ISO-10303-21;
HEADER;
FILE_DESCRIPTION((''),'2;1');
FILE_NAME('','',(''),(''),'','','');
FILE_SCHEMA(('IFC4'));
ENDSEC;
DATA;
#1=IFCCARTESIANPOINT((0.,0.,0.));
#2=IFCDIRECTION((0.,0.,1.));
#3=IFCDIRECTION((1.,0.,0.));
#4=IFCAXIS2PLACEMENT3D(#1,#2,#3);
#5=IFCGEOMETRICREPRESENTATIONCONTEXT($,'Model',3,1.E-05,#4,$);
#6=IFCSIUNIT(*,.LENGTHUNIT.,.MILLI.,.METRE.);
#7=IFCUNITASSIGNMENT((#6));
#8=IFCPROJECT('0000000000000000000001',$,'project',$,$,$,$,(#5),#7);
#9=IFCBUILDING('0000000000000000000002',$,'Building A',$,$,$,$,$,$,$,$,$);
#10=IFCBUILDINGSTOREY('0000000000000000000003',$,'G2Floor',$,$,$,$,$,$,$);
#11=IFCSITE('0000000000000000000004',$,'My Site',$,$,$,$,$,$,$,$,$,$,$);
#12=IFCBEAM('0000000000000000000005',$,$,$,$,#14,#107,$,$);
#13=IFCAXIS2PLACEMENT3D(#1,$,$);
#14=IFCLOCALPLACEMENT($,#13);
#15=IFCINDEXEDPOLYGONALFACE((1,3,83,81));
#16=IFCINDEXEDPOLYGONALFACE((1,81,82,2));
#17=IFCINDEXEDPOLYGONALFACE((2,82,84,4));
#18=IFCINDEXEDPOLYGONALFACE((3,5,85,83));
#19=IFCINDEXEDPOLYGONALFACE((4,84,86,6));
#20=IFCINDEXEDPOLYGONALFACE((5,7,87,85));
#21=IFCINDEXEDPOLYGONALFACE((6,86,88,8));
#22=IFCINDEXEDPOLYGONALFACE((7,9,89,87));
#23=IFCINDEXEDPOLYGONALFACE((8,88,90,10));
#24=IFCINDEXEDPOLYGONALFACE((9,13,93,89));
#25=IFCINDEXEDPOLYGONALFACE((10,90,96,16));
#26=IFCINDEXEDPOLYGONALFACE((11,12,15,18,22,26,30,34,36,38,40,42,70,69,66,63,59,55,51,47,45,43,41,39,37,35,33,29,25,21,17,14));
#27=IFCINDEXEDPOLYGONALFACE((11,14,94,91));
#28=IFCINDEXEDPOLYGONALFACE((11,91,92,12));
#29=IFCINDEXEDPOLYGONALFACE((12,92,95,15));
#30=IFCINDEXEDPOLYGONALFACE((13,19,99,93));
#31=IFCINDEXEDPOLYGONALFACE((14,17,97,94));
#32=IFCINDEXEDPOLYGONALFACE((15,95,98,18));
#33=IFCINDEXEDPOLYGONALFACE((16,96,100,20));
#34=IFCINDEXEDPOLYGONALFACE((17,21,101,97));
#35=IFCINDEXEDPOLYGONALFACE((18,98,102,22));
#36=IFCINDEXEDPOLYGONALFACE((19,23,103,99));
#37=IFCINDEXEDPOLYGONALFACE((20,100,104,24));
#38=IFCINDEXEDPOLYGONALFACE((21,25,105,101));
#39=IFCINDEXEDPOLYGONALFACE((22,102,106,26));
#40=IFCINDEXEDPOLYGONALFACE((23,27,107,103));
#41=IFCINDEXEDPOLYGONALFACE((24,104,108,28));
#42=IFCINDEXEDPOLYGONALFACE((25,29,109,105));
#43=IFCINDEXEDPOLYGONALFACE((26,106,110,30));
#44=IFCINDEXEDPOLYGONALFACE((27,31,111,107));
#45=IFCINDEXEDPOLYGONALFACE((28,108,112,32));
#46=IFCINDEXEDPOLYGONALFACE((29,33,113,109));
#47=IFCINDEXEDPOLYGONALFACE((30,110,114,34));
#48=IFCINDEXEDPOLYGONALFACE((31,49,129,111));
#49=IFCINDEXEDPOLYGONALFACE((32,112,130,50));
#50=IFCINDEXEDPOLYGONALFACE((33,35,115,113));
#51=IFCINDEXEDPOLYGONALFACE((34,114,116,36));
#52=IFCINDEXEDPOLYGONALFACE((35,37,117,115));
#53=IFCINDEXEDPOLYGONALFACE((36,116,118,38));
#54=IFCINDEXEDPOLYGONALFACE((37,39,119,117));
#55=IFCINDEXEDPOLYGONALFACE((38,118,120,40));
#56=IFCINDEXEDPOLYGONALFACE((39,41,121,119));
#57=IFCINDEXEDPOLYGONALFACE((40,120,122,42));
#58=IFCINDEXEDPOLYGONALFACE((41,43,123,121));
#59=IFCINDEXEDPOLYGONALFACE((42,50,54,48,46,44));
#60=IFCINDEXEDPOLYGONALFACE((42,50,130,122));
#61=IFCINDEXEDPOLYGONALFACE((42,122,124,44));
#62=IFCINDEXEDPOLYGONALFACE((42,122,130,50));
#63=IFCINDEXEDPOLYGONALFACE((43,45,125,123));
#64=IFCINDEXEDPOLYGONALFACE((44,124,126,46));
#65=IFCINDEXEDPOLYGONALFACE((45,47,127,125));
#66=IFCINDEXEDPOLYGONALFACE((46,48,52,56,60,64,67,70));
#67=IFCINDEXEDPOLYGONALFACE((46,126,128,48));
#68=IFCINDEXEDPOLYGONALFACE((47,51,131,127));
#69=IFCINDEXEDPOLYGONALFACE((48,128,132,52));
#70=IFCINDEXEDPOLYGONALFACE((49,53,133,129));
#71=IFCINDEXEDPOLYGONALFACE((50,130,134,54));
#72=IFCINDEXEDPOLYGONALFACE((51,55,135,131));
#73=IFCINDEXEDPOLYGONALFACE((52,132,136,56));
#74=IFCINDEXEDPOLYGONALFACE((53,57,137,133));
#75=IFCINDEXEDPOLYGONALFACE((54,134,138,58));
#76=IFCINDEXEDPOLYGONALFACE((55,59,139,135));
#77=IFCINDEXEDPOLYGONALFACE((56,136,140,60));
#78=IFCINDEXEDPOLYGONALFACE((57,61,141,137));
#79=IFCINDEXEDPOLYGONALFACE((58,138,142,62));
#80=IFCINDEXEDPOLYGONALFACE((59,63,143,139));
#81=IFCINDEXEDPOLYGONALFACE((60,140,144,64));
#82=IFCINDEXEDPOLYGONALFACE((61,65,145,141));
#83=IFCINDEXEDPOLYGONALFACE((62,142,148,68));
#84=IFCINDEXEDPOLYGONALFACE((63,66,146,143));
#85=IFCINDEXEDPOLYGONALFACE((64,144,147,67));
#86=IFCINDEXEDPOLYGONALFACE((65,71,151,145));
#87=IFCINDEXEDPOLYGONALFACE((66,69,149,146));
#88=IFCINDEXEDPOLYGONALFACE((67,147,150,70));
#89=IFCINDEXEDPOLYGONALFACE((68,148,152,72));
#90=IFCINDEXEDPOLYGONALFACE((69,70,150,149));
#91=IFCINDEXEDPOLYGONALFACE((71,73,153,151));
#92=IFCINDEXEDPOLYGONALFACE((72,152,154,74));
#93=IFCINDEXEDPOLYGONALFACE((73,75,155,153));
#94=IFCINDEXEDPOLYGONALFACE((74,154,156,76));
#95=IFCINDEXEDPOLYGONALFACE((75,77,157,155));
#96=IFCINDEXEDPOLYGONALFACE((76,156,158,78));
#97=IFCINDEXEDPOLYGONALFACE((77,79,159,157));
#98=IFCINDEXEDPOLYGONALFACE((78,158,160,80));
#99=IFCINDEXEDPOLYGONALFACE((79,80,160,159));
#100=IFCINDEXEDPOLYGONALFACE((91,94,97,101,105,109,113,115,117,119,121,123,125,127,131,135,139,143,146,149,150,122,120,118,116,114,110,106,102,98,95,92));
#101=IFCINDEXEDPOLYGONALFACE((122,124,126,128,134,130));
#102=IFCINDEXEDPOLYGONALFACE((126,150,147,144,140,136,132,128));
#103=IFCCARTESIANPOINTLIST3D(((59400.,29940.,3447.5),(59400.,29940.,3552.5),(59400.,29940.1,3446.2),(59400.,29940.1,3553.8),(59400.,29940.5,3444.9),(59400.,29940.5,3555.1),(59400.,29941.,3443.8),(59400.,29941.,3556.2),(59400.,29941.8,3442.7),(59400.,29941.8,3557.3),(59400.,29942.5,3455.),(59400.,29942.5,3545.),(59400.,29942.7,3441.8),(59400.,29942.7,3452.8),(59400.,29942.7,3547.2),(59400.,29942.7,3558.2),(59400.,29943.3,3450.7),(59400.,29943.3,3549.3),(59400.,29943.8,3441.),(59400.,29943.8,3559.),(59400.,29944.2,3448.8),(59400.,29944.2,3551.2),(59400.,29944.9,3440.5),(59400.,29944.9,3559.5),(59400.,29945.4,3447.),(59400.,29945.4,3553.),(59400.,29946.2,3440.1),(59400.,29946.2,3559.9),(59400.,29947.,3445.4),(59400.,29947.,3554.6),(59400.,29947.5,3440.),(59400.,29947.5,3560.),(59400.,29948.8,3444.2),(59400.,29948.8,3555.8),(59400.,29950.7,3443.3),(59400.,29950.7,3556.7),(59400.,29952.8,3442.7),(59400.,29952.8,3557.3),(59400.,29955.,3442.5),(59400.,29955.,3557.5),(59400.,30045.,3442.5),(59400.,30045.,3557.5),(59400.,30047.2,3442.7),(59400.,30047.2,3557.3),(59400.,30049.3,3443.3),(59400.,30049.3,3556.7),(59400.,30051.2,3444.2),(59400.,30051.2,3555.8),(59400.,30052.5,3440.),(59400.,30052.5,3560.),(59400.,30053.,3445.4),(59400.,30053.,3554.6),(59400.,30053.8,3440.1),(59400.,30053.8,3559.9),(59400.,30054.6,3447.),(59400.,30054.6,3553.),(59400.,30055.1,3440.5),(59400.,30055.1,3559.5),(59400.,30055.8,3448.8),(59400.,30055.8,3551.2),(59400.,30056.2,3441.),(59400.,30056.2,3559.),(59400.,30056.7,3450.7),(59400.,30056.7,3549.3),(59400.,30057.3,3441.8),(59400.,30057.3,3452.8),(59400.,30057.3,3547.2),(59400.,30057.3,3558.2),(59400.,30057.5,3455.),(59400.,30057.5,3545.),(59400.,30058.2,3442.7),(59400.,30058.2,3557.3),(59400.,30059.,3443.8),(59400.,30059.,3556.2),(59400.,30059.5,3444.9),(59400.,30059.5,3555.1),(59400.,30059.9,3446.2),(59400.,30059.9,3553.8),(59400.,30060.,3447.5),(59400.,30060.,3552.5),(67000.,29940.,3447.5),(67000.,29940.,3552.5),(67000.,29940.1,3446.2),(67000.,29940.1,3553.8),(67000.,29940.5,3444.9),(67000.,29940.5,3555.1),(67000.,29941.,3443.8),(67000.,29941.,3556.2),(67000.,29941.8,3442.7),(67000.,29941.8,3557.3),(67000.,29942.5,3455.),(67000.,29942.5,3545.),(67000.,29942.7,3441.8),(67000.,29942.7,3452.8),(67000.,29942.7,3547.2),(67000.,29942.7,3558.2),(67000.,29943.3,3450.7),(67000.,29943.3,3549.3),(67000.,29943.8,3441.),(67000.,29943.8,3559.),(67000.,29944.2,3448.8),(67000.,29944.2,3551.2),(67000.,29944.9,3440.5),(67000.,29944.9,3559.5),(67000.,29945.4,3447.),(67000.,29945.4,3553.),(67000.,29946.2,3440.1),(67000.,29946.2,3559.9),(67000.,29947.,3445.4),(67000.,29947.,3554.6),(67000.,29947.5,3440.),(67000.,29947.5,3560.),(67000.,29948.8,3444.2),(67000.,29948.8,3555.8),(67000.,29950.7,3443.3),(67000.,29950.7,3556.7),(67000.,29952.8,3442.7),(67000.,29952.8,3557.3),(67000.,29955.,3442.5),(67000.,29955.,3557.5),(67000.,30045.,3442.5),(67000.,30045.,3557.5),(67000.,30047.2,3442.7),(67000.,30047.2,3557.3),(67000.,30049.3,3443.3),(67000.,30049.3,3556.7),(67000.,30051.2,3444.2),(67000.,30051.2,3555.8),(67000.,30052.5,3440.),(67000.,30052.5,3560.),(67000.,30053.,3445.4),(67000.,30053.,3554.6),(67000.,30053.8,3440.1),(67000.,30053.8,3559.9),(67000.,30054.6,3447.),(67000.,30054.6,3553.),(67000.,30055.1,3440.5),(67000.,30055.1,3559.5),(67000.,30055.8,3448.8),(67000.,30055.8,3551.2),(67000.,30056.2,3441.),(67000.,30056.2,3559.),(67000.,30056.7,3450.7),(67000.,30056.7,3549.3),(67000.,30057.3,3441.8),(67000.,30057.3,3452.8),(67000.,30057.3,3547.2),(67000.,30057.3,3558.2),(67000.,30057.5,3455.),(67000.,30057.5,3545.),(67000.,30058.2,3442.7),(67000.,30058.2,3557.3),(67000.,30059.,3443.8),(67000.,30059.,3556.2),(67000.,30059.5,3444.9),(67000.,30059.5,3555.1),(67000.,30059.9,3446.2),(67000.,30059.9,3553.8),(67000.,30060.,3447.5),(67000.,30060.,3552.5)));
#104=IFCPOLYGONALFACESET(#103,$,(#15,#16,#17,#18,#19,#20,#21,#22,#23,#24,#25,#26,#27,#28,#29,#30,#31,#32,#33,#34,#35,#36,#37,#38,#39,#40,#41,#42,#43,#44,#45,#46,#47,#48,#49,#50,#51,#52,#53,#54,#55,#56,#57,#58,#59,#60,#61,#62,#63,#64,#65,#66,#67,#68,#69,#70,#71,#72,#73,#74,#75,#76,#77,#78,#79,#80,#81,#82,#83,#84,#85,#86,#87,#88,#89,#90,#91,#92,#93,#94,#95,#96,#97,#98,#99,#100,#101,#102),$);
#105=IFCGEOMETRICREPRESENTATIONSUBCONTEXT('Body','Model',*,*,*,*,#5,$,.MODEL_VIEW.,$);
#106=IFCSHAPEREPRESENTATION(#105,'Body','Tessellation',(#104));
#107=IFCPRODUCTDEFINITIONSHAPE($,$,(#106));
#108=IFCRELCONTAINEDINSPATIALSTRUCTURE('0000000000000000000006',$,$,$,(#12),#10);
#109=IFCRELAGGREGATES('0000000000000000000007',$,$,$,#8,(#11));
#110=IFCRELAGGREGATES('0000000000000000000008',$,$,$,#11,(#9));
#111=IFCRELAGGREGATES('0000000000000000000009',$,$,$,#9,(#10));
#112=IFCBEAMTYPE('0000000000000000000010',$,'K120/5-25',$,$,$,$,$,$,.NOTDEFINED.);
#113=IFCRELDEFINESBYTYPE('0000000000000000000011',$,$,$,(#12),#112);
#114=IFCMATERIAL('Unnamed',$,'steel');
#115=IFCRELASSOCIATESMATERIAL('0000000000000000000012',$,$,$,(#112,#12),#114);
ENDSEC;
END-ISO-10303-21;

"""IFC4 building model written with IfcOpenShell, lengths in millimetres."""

from ifc_helpers import new_model, si_unit, frame, origin_with_axes, place, context, subcontext, project, spatial, polyline, outline, extrude, material, material_profile, profile_set, profile_usage, type_object, element, save


model = new_model("IFC4")

# Units and contexts
model_context = context("Model", 3, precision=1e-05, world=origin_with_axes())
body_context = subcontext(model_context, "Body", "Model", "MODEL_VIEW")
ifc_project = project(units=[si_unit("LENGTHUNIT", "METRE", prefix="MILLI")], contexts=[model_context])

# Site, building, storey
site = spatial("IfcSite", under=ifc_project, Name="My Site")
building = spatial("IfcBuilding", under=site, Name="Building A")
storey = spatial("IfcBuildingStorey", under=building, Name="G2Floor")

# Beam
ifc_material_1 = material(Name="Unnamed", Category="steel")
ifc_material_profile_1 = material_profile(ifc_material_1, outline(polyline([(-52.5, -60.0), (52.5, -60.0), (52.5, -60.0), (53.8, -59.9), (53.8, -59.9), (55.1, -59.5), (55.1, -59.5), (56.2, -59.0), (56.2, -59.0), (57.3, -58.2), (57.3, -58.2), (58.2, -57.3), (58.2, -57.3), (59.0, -56.2), (59.0, -56.2), (59.5, -55.1), (59.5, -55.1), (59.9, -53.8), (59.9, -53.8), (60.0, -52.5), (60.0, -52.5), (60.0, 52.5), (60.0, 52.5), (59.9, 53.8), (59.9, 53.8), (59.5, 55.1), (59.5, 55.1), (59.0, 56.2), (59.0, 56.2), (58.2, 57.3), (58.2, 57.3), (57.3, 58.2), (57.3, 58.2), (56.2, 59.0), (56.2, 59.0), (55.1, 59.5), (55.1, 59.5), (53.8, 59.9), (53.8, 59.9), (52.5, 60.0), (52.5, 60.0), (-52.5, 60.0), (-52.5, 60.0), (-53.8, 59.9), (-53.8, 59.9), (-55.1, 59.5), (-55.1, 59.5), (-56.2, 59.0), (-56.2, 59.0), (-57.3, 58.2), (-57.3, 58.2), (-58.2, 57.3), (-58.2, 57.3), (-59.0, 56.2), (-59.0, 56.2), (-59.5, 55.1), (-59.5, 55.1), (-59.9, 53.8), (-59.9, 53.8), (-60.0, 52.5), (-60.0, 52.5), (-60.0, -52.5), (-60.0, -52.5), (-59.9, -53.8), (-59.9, -53.8), (-59.5, -55.1), (-59.5, -55.1), (-59.0, -56.2), (-59.0, -56.2), (-58.2, -57.3), (-58.2, -57.3), (-57.3, -58.2), (-57.3, -58.2), (-56.2, -59.0), (-56.2, -59.0), (-55.1, -59.5), (-55.1, -59.5), (-53.8, -59.9), (-53.8, -59.9), (-52.5, -60.0), (-52.5, -60.0), (-45.0, -57.5), (-45.0, -57.5), (45.0, -57.5), (45.0, -57.5), (47.2, -57.3), (47.2, -57.3), (49.3, -56.7), (49.3, -56.7), (51.2, -55.8), (51.2, -55.8), (53.0, -54.6), (53.0, -54.6), (54.6, -53.0), (54.6, -53.0), (55.8, -51.2), (55.8, -51.2), (56.7, -49.3), (56.7, -49.3), (57.3, -47.2), (57.3, -47.2), (57.5, -45.0), (57.5, -45.0), (57.5, 45.0), (57.5, 45.0), (57.3, 47.2), (57.3, 47.2), (56.7, 49.3), (56.7, 49.3), (55.8, 51.2), (55.8, 51.2), (54.6, 53.0), (54.6, 53.0), (53.0, 54.6), (53.0, 54.6), (51.2, 55.8), (51.2, 55.8), (49.3, 56.7), (49.3, 56.7), (47.2, 57.3), (47.2, 57.3), (45.0, 57.5), (45.0, 57.5), (-45.0, 57.5), (-45.0, 57.5), (-47.2, 57.3), (-47.2, 57.3), (-49.3, 56.7), (-49.3, 56.7), (-51.2, 55.8), (-51.2, 55.8), (-53.0, 54.6), (-53.0, 54.6), (-54.6, 53.0), (-54.6, 53.0), (-55.8, 51.2), (-55.8, 51.2), (-56.7, 49.3), (-56.7, 49.3), (-57.3, 47.2), (-57.3, 47.2), (-57.5, 45.0), (-57.5, 45.0), (-57.5, -45.0), (-57.5, -45.0), (-57.3, -47.2), (-57.3, -47.2), (-56.7, -49.3), (-56.7, -49.3), (-55.8, -51.2), (-55.8, -51.2), (-54.6, -53.0), (-54.6, -53.0), (-53.0, -54.6), (-53.0, -54.6), (-51.2, -55.8), (-51.2, -55.8), (-49.3, -56.7), (-49.3, -56.7), (-47.2, -57.3), (-47.2, -57.3), (-45.0, -57.5), (-45.0, -57.5), (-52.5, -60.0)])))
ifc_profile_set_1 = profile_set([ifc_material_profile_1], Name="K120/5-25")
ifc_profile_usage_1 = profile_usage(ifc_profile_set_1)
beam_type_1 = type_object("IfcBeamType", Name="K120/5-25", PredefinedType="NOTDEFINED", material=ifc_profile_set_1)
beam_1_placement = place(None, frame((59400.0, 30000.0, 3500.0), z_axis=(1.0, 0.0, 0.0), x_axis=(0.0, -1.0, 0.0)))
element("IfcBeam", 1, at=beam_1_placement, inside=storey, type_object=beam_type_1, material=ifc_profile_usage_1, context=body_context, shape_type="SweptSolid", body=[
    extrude(outline(polyline([(-52.5, -60.0), (52.5, -60.0), (52.5, -60.0), (53.8, -59.9), (53.8, -59.9), (55.1, -59.5), (55.1, -59.5), (56.2, -59.0), (56.2, -59.0), (57.3, -58.2), (57.3, -58.2), (58.2, -57.3), (58.2, -57.3), (59.0, -56.2), (59.0, -56.2), (59.5, -55.1), (59.5, -55.1), (59.9, -53.8), (59.9, -53.8), (60.0, -52.5), (60.0, -52.5), (60.0, 52.5), (60.0, 52.5), (59.9, 53.8), (59.9, 53.8), (59.5, 55.1), (59.5, 55.1), (59.0, 56.2), (59.0, 56.2), (58.2, 57.3), (58.2, 57.3), (57.3, 58.2), (57.3, 58.2), (56.2, 59.0), (56.2, 59.0), (55.1, 59.5), (55.1, 59.5), (53.8, 59.9), (53.8, 59.9), (52.5, 60.0), (52.5, 60.0), (-52.5, 60.0), (-52.5, 60.0), (-53.8, 59.9), (-53.8, 59.9), (-55.1, 59.5), (-55.1, 59.5), (-56.2, 59.0), (-56.2, 59.0), (-57.3, 58.2), (-57.3, 58.2), (-58.2, 57.3), (-58.2, 57.3), (-59.0, 56.2), (-59.0, 56.2), (-59.5, 55.1), (-59.5, 55.1), (-59.9, 53.8), (-59.9, 53.8), (-60.0, 52.5), (-60.0, 52.5), (-60.0, -52.5), (-60.0, -52.5), (-59.9, -53.8), (-59.9, -53.8), (-59.5, -55.1), (-59.5, -55.1), (-59.0, -56.2), (-59.0, -56.2), (-58.2, -57.3), (-58.2, -57.3), (-57.3, -58.2), (-57.3, -58.2), (-56.2, -59.0), (-56.2, -59.0), (-55.1, -59.5), (-55.1, -59.5), (-53.8, -59.9), (-53.8, -59.9), (-52.5, -60.0), (-52.5, -60.0), (-45.0, -57.5), (-45.0, -57.5), (45.0, -57.5), (45.0, -57.5), (47.2, -57.3), (47.2, -57.3), (49.3, -56.7), (49.3, -56.7), (51.2, -55.8), (51.2, -55.8), (53.0, -54.6), (53.0, -54.6), (54.6, -53.0), (54.6, -53.0), (55.8, -51.2), (55.8, -51.2), (56.7, -49.3), (56.7, -49.3), (57.3, -47.2), (57.3, -47.2), (57.5, -45.0), (57.5, -45.0), (57.5, 45.0), (57.5, 45.0), (57.3, 47.2), (57.3, 47.2), (56.7, 49.3), (56.7, 49.3), (55.8, 51.2), (55.8, 51.2), (54.6, 53.0), (54.6, 53.0), (53.0, 54.6), (53.0, 54.6), (51.2, 55.8), (51.2, 55.8), (49.3, 56.7), (49.3, 56.7), (47.2, 57.3), (47.2, 57.3), (45.0, 57.5), (45.0, 57.5), (-45.0, 57.5), (-45.0, 57.5), (-47.2, 57.3), (-47.2, 57.3), (-49.3, 56.7), (-49.3, 56.7), (-51.2, 55.8), (-51.2, 55.8), (-53.0, 54.6), (-53.0, 54.6), (-54.6, 53.0), (-54.6, 53.0), (-55.8, 51.2), (-55.8, 51.2), (-56.7, 49.3), (-56.7, 49.3), (-57.3, 47.2), (-57.3, 47.2), (-57.5, 45.0), (-57.5, 45.0), (-57.5, -45.0), (-57.5, -45.0), (-57.3, -47.2), (-57.3, -47.2), (-56.7, -49.3), (-56.7, -49.3), (-55.8, -51.2), (-55.8, -51.2), (-54.6, -53.0), (-54.6, -53.0), (-53.0, -54.6), (-53.0, -54.6), (-51.2, -55.8), (-51.2, -55.8), (-49.3, -56.7), (-49.3, -56.7), (-47.2, -57.3), (-47.2, -57.3), (-45.0, -57.5), (-45.0, -57.5), (-52.5, -60.0)])), origin_with_axes(), (0.0, 0.0, 1.0), 7600.0),
])

save(model, "model.ifc")
